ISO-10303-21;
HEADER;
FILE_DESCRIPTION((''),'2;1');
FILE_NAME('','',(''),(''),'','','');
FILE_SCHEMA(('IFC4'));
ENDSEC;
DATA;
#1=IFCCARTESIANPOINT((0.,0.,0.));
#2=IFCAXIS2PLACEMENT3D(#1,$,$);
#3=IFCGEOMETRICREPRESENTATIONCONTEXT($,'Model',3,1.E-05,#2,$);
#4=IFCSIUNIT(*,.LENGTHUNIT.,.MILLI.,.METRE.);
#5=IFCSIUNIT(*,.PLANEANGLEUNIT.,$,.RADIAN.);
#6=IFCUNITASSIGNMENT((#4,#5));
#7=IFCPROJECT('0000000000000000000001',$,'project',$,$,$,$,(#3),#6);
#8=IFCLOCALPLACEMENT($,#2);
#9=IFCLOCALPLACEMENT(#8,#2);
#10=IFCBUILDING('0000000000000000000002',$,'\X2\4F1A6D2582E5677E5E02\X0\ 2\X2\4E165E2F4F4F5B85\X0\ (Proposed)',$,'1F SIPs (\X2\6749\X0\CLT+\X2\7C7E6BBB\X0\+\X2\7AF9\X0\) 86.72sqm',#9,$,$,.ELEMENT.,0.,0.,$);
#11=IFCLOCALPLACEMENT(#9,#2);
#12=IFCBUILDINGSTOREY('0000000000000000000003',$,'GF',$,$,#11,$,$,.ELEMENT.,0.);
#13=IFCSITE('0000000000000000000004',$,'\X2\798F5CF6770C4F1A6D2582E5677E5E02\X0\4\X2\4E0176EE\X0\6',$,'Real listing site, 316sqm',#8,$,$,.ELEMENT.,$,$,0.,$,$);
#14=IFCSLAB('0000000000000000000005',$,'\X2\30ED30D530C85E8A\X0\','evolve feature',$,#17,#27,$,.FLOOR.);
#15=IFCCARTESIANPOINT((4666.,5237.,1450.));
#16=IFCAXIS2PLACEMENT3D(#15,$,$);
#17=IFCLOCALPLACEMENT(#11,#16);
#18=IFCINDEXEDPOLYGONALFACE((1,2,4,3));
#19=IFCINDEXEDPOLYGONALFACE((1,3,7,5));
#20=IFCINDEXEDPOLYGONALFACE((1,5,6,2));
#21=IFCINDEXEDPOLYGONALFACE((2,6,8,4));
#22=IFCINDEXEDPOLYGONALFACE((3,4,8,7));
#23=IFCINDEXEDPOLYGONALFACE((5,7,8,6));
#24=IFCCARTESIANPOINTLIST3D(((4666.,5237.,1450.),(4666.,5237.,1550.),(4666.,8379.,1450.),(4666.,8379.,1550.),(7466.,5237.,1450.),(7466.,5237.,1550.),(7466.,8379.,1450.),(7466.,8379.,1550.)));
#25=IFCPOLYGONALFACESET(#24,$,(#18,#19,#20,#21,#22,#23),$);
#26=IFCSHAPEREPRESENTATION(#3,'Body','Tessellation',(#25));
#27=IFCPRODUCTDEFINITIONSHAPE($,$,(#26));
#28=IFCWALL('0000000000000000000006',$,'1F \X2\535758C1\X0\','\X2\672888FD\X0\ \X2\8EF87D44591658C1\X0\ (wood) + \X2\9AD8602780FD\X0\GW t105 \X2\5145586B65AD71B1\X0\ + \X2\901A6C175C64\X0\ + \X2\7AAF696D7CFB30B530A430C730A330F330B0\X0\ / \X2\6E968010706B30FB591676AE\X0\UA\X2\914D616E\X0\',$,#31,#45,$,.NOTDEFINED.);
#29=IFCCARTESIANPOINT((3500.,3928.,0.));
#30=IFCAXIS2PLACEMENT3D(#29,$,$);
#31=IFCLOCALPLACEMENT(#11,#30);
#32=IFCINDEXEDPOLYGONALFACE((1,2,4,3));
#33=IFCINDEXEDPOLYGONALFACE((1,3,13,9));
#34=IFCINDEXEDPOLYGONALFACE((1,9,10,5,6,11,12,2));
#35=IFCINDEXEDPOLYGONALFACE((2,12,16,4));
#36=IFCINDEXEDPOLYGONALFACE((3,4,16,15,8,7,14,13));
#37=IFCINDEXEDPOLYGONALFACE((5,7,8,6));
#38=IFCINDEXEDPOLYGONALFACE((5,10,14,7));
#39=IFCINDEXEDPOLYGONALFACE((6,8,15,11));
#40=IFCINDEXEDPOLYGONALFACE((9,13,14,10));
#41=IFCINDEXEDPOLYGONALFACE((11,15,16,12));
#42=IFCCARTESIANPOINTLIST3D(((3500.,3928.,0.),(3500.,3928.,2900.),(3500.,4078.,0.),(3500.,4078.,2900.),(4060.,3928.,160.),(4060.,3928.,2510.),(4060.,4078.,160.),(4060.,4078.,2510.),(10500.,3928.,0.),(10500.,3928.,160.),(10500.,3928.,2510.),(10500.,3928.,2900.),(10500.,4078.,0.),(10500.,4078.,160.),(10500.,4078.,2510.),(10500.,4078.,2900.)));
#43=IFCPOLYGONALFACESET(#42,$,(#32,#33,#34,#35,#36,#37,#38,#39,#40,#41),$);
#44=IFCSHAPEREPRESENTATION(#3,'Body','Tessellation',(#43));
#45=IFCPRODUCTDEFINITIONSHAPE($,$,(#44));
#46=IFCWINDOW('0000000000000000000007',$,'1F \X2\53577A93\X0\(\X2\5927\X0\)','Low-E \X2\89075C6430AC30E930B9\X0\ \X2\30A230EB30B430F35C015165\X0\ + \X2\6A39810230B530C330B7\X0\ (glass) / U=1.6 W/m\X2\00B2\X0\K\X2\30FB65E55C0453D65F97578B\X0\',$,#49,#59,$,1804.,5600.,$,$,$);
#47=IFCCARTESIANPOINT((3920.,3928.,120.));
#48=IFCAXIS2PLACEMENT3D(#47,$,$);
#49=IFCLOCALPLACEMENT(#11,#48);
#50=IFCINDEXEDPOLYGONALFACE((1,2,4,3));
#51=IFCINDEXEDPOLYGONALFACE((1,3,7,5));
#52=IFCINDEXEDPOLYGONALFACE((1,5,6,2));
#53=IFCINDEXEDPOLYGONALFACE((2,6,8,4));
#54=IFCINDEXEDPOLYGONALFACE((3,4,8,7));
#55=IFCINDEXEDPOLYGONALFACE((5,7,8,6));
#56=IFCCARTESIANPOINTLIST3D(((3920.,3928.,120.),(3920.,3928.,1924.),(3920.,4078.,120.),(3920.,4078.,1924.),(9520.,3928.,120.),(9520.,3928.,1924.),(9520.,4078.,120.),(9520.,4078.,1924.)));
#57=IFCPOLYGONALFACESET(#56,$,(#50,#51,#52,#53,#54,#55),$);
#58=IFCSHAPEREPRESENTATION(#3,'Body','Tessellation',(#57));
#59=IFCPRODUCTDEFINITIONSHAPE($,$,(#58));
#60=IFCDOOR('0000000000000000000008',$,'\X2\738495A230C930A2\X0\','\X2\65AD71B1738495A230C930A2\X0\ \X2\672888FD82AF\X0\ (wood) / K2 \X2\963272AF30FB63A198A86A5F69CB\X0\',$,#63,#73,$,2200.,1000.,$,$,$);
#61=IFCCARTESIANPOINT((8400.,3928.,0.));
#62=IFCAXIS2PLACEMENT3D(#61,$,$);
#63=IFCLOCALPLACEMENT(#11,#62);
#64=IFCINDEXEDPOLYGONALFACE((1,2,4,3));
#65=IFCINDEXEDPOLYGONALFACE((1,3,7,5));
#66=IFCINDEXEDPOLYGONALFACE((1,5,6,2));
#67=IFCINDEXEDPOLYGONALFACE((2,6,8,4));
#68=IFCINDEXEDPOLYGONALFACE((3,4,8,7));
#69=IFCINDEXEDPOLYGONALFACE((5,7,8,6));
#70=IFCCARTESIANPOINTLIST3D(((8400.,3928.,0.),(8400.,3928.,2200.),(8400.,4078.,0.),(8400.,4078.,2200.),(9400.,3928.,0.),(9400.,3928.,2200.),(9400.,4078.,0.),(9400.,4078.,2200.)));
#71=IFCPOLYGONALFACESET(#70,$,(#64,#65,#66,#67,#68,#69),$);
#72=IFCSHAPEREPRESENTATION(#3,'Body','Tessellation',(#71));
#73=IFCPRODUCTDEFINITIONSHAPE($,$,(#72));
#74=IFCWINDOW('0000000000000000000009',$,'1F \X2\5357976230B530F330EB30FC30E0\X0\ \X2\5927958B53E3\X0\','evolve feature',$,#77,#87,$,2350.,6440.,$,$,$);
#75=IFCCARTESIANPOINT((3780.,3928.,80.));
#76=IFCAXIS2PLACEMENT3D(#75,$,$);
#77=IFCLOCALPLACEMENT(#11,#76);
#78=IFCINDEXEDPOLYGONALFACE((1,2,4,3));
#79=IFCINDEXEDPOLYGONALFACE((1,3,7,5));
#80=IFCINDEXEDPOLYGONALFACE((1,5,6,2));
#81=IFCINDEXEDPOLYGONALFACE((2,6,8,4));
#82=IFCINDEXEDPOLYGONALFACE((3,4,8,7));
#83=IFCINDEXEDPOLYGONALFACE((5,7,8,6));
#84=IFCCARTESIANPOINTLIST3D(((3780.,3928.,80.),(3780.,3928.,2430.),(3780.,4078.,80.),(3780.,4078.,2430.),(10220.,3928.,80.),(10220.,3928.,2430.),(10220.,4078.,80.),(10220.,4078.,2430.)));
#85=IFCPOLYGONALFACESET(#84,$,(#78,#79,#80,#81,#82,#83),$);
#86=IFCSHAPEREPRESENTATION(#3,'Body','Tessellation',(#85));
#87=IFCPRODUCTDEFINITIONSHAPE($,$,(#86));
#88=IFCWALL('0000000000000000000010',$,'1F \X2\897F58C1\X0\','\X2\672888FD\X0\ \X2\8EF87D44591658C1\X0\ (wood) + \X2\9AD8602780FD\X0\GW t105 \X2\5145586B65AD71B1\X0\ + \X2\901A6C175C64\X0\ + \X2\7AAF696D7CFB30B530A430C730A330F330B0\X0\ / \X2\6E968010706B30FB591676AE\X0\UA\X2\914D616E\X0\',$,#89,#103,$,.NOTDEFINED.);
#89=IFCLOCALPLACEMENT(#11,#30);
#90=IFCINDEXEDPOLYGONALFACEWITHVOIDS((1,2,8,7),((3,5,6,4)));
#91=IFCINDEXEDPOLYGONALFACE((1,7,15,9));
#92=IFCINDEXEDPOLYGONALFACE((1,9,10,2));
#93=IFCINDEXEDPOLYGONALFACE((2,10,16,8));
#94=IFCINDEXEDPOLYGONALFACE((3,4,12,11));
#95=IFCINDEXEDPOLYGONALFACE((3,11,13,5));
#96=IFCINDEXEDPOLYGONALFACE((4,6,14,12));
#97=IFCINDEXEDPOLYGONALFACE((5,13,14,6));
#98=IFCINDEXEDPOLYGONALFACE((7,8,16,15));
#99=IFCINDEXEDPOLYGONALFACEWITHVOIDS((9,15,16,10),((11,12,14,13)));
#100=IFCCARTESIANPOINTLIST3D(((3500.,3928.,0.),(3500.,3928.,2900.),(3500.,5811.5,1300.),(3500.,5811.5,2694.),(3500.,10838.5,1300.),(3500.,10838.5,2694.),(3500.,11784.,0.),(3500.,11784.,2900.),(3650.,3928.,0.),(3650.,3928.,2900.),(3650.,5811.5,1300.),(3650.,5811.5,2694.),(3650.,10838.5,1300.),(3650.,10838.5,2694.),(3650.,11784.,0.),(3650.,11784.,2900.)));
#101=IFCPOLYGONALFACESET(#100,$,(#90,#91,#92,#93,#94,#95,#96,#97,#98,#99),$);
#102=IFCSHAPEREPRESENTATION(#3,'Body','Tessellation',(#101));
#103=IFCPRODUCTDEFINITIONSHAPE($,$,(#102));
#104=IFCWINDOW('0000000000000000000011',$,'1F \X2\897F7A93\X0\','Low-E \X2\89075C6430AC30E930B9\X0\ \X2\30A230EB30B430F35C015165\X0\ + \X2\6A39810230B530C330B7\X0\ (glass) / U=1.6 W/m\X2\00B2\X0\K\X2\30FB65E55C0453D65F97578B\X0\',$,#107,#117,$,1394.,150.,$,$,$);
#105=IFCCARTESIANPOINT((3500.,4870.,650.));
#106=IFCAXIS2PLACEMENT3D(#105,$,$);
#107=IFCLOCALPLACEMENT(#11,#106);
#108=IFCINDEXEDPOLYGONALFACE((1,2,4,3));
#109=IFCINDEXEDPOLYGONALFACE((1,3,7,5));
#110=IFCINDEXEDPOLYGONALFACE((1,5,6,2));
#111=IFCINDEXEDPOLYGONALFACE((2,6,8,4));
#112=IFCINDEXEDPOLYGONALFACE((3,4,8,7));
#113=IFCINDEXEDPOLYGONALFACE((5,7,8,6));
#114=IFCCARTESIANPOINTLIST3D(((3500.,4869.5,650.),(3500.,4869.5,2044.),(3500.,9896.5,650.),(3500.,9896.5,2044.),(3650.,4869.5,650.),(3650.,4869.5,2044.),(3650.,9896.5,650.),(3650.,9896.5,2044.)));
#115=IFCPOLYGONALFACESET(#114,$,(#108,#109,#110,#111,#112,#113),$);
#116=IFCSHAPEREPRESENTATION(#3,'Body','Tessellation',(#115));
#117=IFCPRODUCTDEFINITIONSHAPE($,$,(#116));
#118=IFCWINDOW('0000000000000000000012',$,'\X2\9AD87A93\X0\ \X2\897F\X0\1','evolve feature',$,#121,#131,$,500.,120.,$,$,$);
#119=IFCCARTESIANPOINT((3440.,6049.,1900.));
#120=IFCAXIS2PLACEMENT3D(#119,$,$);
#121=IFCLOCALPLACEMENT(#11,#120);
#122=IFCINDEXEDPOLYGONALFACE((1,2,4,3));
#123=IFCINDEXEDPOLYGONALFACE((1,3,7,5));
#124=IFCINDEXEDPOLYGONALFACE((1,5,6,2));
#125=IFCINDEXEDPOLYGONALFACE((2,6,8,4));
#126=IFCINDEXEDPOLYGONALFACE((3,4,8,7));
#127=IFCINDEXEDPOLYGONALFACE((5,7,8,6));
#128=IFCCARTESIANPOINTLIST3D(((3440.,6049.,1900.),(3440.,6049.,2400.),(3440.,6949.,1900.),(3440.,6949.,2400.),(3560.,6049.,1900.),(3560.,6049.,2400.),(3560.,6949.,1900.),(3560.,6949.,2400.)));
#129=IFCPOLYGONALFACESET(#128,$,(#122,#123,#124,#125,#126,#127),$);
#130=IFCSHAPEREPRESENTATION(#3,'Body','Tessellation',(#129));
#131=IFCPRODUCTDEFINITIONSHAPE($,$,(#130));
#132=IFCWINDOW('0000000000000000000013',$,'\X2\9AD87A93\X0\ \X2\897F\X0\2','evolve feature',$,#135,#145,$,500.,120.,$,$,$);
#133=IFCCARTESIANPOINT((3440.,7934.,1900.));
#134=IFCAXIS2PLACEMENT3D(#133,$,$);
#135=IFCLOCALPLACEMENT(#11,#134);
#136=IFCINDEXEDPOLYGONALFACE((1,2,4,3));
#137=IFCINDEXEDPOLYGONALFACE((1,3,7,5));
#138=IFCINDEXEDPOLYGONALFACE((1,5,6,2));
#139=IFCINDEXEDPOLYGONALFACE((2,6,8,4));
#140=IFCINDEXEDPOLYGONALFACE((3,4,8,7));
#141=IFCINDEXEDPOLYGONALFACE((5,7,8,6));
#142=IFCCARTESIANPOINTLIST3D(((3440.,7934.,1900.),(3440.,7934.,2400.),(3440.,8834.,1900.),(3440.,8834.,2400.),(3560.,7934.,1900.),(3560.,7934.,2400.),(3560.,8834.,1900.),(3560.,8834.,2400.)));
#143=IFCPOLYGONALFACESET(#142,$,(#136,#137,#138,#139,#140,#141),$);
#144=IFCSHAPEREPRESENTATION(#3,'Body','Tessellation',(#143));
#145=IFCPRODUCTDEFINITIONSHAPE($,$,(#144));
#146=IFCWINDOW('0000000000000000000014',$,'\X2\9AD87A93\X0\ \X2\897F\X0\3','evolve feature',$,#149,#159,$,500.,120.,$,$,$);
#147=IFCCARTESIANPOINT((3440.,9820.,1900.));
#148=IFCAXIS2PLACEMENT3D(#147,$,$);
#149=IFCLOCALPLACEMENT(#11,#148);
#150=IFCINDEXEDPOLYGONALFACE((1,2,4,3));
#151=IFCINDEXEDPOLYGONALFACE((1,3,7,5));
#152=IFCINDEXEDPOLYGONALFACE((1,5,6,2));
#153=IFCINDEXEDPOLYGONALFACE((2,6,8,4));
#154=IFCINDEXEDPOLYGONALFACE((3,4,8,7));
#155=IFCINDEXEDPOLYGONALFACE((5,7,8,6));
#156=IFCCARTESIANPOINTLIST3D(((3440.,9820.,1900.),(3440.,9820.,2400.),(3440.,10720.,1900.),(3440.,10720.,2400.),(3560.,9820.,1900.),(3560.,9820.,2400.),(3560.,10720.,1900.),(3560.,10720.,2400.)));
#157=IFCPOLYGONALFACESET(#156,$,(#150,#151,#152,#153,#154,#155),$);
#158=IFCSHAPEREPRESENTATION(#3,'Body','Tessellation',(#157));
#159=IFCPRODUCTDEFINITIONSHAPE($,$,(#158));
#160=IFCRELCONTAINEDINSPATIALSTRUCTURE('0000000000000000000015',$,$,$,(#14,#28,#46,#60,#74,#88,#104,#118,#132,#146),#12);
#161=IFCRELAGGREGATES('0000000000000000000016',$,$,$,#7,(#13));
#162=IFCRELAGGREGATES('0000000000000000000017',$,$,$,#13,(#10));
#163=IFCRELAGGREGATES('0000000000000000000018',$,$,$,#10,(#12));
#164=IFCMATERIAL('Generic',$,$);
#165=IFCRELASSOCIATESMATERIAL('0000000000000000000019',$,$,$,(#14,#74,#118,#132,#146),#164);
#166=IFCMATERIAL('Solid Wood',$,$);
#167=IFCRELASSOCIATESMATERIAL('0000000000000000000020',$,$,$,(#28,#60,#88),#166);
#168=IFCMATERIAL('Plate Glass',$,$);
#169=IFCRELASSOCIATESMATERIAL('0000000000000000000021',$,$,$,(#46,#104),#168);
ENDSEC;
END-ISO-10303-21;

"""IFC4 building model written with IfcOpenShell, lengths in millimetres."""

from ifc_helpers import new_model, si_unit, frame, frame_2d, origin, place, context, project, spatial, rectangle, extrude, material, element, fill, save


model = new_model("IFC4")

# Units and contexts
model_context = context("Model", 3, precision=1e-05, world=origin())
ifc_project = project(units=[si_unit("LENGTHUNIT", "METRE", prefix="MILLI"), si_unit("PLANEANGLEUNIT", "RADIAN")], contexts=[model_context])

# Site, building, storey
site_placement = place(None, origin())
site = spatial("IfcSite", under=ifc_project, at=site_placement, Name="福島県会津若松市4丁目6", ObjectType="Real listing site, 316sqm", CompositionType="ELEMENT", RefElevation=0.0)
building_placement = place(site_placement, origin())
building = spatial("IfcBuilding", under=site, at=building_placement, Name="会津若松市 2世帯住宅 (Proposed)", ObjectType="1F SIPs (杉CLT+籾殻+竹) 86.72sqm", CompositionType="ELEMENT", ElevationOfRefHeight=0.0, ElevationOfTerrain=0.0)
storey_placement = place(building_placement, origin())
storey = spatial("IfcBuildingStorey", under=building, at=storey_placement, Name="GF", CompositionType="ELEMENT", Elevation=0.0)

# Slab
ifc_material_1 = material(Name="Solid Wood")
ifc_material_2 = material(Name="Generic")
slab_1_placement = place(storey_placement, frame((4666.0, 5237.0, 1450.0)))
element("IfcSlab", 1, at=slab_1_placement, inside=storey, material=ifc_material_2, Name="ロフト床", Description="evolve feature", PredefinedType="FLOOR", context=model_context, shape_type="SweptSolid", body=[
    extrude(rectangle(XDim=2800.0, YDim=3142.0, at=frame_2d((1400.0, 1571.0))), frame((4666.0, 5237.0, 1450.0)), (0.0, 0.0, 1.0), 100.0),
])

# Wall, openings, windows, door
wall_1_placement = place(storey_placement, frame((3500.0, 3928.0, 0.0)))
wall_1 = element("IfcWall", 2, at=wall_1_placement, inside=storey, material=ifc_material_1, Name="1F 南壁", Description="木製 軸組外壁 (wood) + 高性能GW t105 充填断熱 + 通気層 + 窯業系サイディング / 準耐火・外皮UA配慮", PredefinedType="NOTDEFINED", context=model_context, shape_type="SweptSolid", body=[
    extrude(rectangle(XDim=7000.0, YDim=150.0, at=frame_2d((3500.0, 75.0))), frame((3500.0, 3928.0, 0.0)), (0.0, 0.0, 1.0), 2900.0),
])
opening_1_placement = place(storey_placement, frame((3920.0, 3928.0, 120.0)))
opening_1 = element("IfcOpeningElement", 3, at=opening_1_placement, cuts=wall_1, PredefinedType="NOTDEFINED", context=model_context, shape_type="SweptSolid", body=[
    extrude(rectangle(XDim=5600.0, YDim=150.0, at=frame_2d((2800.0, 75.0))), frame((3920.0, 3928.0, 120.0)), (0.0, 0.0, 1.0), 1804.0),
])
opening_2_placement = place(storey_placement, frame((8400.0, 3928.0, 0.0)))
opening_2 = element("IfcOpeningElement", 4, at=opening_2_placement, cuts=wall_1, PredefinedType="NOTDEFINED", context=model_context, shape_type="SweptSolid", body=[
    extrude(rectangle(XDim=1000.0, YDim=150.0, at=frame_2d((500.0, 75.0))), frame((8400.0, 3928.0, 0.0)), (0.0, 0.0, 1.0), 2200.0),
])
opening_3_placement = place(storey_placement, frame((3780.0, 3928.0, 80.0)))
opening_3 = element("IfcOpeningElement", 5, at=opening_3_placement, cuts=wall_1, PredefinedType="NOTDEFINED", context=model_context, shape_type="SweptSolid", body=[
    extrude(rectangle(XDim=6440.0, YDim=150.0, at=frame_2d((3220.0, 75.0))), frame((3780.0, 3928.0, 80.0)), (0.0, 0.0, 1.0), 2350.0),
])
ifc_material_3 = material(Name="Plate Glass")
window_1_placement = place(storey_placement, frame((3920.0, 3928.0, 120.0)))
window_1 = element("IfcWindow", 6, at=window_1_placement, inside=storey, material=ifc_material_3, Name="1F 南窓(大)", Description="Low-E 複層ガラス アルゴン封入 + 樹脂サッシ (glass) / U=1.6 W/m²K・日射取得型", OverallHeight=1804.0, OverallWidth=5600.0, context=model_context, shape_type="SweptSolid", body=[
    extrude(rectangle(XDim=5600.0, YDim=150.0, at=frame_2d((2800.0, 75.0))), frame((3920.0, 3928.0, 120.0)), (0.0, 0.0, 1.0), 1804.0),
])
fill(opening_1, window_1)
door_placement = place(storey_placement, frame((8400.0, 3928.0, 0.0)))
door = element("IfcDoor", 7, at=door_placement, inside=storey, material=ifc_material_1, Name="玄関ドア", Description="断熱玄関ドア 木製芯 (wood) / K2 防犯・採風機構", OverallHeight=2200.0, OverallWidth=1000.0, context=model_context, shape_type="SweptSolid", body=[
    extrude(rectangle(XDim=1000.0, YDim=150.0, at=frame_2d((500.0, 75.0))), frame((8400.0, 3928.0, 0.0)), (0.0, 0.0, 1.0), 2200.0),
])
fill(opening_2, door)
window_2_placement = place(storey_placement, frame((3780.0, 3928.0, 80.0)))
window_2 = element("IfcWindow", 8, at=window_2_placement, inside=storey, material=ifc_material_2, Name="1F 南面サンルーム 大開口", Description="evolve feature", OverallHeight=2350.0, OverallWidth=6440.0, context=model_context, shape_type="SweptSolid", body=[
    extrude(rectangle(XDim=6440.0, YDim=150.0, at=frame_2d((3220.0, 75.0))), frame((3780.0, 3928.0, 80.0)), (0.0, 0.0, 1.0), 2350.0),
])
fill(opening_3, window_2)

# Wall, openings, windows
wall_2_placement = place(storey_placement, frame((3500.0, 3928.0, 0.0)))
wall_2 = element("IfcWall", 9, at=wall_2_placement, inside=storey, material=ifc_material_1, Name="1F 西壁", Description="木製 軸組外壁 (wood) + 高性能GW t105 充填断熱 + 通気層 + 窯業系サイディング / 準耐火・外皮UA配慮", PredefinedType="NOTDEFINED", context=model_context, shape_type="SweptSolid", body=[
    extrude(rectangle(XDim=150.0, YDim=7856.0, at=frame_2d((75.0, 3928.0))), frame((3500.0, 3928.0, 0.0)), (0.0, 0.0, 1.0), 2900.0),
])
opening_4_placement = place(storey_placement, frame((3500.0, 4870.0, 650.0)))
opening_4 = element("IfcOpeningElement", 10, at=opening_4_placement, cuts=wall_2, PredefinedType="NOTDEFINED", context=model_context, shape_type="SweptSolid", body=[
    extrude(rectangle(XDim=150.0, YDim=5027.0, at=frame_2d((75.0, 2513.0))), frame((3500.0, 4870.0, 650.0)), (0.0, 0.0, 1.0), 1394.0),
])
opening_5_placement = place(storey_placement, frame((3440.0, 6049.0, 1900.0)))
opening_5 = element("IfcOpeningElement", 11, at=opening_5_placement, cuts=wall_2, PredefinedType="NOTDEFINED", context=model_context, shape_type="SweptSolid", body=[
    extrude(rectangle(XDim=120.0, YDim=900.0, at=frame_2d((60.0, 450.0))), frame((3440.0, 6049.0, 1900.0)), (0.0, 0.0, 1.0), 500.0),
])
opening_6_placement = place(storey_placement, frame((3440.0, 7934.0, 1900.0)))
opening_6 = element("IfcOpeningElement", 12, at=opening_6_placement, cuts=wall_2, PredefinedType="NOTDEFINED", context=model_context, shape_type="SweptSolid", body=[
    extrude(rectangle(XDim=120.0, YDim=900.0, at=frame_2d((60.0, 450.0))), frame((3440.0, 7934.0, 1900.0)), (0.0, 0.0, 1.0), 500.0),
])
opening_7_placement = place(storey_placement, frame((3440.0, 9820.0, 1900.0)))
opening_7 = element("IfcOpeningElement", 13, at=opening_7_placement, cuts=wall_2, PredefinedType="NOTDEFINED", context=model_context, shape_type="SweptSolid", body=[
    extrude(rectangle(XDim=120.0, YDim=900.0, at=frame_2d((60.0, 450.0))), frame((3440.0, 9820.0, 1900.0)), (0.0, 0.0, 1.0), 500.0),
])
window_3_placement = place(storey_placement, frame((3500.0, 4870.0, 650.0)))
window_3 = element("IfcWindow", 14, at=window_3_placement, inside=storey, material=ifc_material_3, Name="1F 西窓", Description="Low-E 複層ガラス アルゴン封入 + 樹脂サッシ (glass) / U=1.6 W/m²K・日射取得型", OverallHeight=1394.0, OverallWidth=150.0, context=model_context, shape_type="SweptSolid", body=[
    extrude(rectangle(XDim=150.0, YDim=5027.0, at=frame_2d((75.0, 2513.0))), frame((3500.0, 4870.0, 650.0)), (0.0, 0.0, 1.0), 1394.0),
])
fill(opening_4, window_3)
window_4_placement = place(storey_placement, frame((3440.0, 6049.0, 1900.0)))
window_4 = element("IfcWindow", 15, at=window_4_placement, inside=storey, material=ifc_material_2, Name="高窓 西1", Description="evolve feature", OverallHeight=500.0, OverallWidth=120.0, context=model_context, shape_type="SweptSolid", body=[
    extrude(rectangle(XDim=120.0, YDim=900.0, at=frame_2d((60.0, 450.0))), frame((3440.0, 6049.0, 1900.0)), (0.0, 0.0, 1.0), 500.0),
])
fill(opening_5, window_4)
window_5_placement = place(storey_placement, frame((3440.0, 7934.0, 1900.0)))
window_5 = element("IfcWindow", 16, at=window_5_placement, inside=storey, material=ifc_material_2, Name="高窓 西2", Description="evolve feature", OverallHeight=500.0, OverallWidth=120.0, context=model_context, shape_type="SweptSolid", body=[
    extrude(rectangle(XDim=120.0, YDim=900.0, at=frame_2d((60.0, 450.0))), frame((3440.0, 7934.0, 1900.0)), (0.0, 0.0, 1.0), 500.0),
])
fill(opening_6, window_5)
window_6_placement = place(storey_placement, frame((3440.0, 9820.0, 1900.0)))
window_6 = element("IfcWindow", 17, at=window_6_placement, inside=storey, material=ifc_material_2, Name="高窓 西3", Description="evolve feature", OverallHeight=500.0, OverallWidth=120.0, context=model_context, shape_type="SweptSolid", body=[
    extrude(rectangle(XDim=120.0, YDim=900.0, at=frame_2d((60.0, 450.0))), frame((3440.0, 9820.0, 1900.0)), (0.0, 0.0, 1.0), 500.0),
])
fill(opening_7, window_6)

save(model, "model.ifc")
